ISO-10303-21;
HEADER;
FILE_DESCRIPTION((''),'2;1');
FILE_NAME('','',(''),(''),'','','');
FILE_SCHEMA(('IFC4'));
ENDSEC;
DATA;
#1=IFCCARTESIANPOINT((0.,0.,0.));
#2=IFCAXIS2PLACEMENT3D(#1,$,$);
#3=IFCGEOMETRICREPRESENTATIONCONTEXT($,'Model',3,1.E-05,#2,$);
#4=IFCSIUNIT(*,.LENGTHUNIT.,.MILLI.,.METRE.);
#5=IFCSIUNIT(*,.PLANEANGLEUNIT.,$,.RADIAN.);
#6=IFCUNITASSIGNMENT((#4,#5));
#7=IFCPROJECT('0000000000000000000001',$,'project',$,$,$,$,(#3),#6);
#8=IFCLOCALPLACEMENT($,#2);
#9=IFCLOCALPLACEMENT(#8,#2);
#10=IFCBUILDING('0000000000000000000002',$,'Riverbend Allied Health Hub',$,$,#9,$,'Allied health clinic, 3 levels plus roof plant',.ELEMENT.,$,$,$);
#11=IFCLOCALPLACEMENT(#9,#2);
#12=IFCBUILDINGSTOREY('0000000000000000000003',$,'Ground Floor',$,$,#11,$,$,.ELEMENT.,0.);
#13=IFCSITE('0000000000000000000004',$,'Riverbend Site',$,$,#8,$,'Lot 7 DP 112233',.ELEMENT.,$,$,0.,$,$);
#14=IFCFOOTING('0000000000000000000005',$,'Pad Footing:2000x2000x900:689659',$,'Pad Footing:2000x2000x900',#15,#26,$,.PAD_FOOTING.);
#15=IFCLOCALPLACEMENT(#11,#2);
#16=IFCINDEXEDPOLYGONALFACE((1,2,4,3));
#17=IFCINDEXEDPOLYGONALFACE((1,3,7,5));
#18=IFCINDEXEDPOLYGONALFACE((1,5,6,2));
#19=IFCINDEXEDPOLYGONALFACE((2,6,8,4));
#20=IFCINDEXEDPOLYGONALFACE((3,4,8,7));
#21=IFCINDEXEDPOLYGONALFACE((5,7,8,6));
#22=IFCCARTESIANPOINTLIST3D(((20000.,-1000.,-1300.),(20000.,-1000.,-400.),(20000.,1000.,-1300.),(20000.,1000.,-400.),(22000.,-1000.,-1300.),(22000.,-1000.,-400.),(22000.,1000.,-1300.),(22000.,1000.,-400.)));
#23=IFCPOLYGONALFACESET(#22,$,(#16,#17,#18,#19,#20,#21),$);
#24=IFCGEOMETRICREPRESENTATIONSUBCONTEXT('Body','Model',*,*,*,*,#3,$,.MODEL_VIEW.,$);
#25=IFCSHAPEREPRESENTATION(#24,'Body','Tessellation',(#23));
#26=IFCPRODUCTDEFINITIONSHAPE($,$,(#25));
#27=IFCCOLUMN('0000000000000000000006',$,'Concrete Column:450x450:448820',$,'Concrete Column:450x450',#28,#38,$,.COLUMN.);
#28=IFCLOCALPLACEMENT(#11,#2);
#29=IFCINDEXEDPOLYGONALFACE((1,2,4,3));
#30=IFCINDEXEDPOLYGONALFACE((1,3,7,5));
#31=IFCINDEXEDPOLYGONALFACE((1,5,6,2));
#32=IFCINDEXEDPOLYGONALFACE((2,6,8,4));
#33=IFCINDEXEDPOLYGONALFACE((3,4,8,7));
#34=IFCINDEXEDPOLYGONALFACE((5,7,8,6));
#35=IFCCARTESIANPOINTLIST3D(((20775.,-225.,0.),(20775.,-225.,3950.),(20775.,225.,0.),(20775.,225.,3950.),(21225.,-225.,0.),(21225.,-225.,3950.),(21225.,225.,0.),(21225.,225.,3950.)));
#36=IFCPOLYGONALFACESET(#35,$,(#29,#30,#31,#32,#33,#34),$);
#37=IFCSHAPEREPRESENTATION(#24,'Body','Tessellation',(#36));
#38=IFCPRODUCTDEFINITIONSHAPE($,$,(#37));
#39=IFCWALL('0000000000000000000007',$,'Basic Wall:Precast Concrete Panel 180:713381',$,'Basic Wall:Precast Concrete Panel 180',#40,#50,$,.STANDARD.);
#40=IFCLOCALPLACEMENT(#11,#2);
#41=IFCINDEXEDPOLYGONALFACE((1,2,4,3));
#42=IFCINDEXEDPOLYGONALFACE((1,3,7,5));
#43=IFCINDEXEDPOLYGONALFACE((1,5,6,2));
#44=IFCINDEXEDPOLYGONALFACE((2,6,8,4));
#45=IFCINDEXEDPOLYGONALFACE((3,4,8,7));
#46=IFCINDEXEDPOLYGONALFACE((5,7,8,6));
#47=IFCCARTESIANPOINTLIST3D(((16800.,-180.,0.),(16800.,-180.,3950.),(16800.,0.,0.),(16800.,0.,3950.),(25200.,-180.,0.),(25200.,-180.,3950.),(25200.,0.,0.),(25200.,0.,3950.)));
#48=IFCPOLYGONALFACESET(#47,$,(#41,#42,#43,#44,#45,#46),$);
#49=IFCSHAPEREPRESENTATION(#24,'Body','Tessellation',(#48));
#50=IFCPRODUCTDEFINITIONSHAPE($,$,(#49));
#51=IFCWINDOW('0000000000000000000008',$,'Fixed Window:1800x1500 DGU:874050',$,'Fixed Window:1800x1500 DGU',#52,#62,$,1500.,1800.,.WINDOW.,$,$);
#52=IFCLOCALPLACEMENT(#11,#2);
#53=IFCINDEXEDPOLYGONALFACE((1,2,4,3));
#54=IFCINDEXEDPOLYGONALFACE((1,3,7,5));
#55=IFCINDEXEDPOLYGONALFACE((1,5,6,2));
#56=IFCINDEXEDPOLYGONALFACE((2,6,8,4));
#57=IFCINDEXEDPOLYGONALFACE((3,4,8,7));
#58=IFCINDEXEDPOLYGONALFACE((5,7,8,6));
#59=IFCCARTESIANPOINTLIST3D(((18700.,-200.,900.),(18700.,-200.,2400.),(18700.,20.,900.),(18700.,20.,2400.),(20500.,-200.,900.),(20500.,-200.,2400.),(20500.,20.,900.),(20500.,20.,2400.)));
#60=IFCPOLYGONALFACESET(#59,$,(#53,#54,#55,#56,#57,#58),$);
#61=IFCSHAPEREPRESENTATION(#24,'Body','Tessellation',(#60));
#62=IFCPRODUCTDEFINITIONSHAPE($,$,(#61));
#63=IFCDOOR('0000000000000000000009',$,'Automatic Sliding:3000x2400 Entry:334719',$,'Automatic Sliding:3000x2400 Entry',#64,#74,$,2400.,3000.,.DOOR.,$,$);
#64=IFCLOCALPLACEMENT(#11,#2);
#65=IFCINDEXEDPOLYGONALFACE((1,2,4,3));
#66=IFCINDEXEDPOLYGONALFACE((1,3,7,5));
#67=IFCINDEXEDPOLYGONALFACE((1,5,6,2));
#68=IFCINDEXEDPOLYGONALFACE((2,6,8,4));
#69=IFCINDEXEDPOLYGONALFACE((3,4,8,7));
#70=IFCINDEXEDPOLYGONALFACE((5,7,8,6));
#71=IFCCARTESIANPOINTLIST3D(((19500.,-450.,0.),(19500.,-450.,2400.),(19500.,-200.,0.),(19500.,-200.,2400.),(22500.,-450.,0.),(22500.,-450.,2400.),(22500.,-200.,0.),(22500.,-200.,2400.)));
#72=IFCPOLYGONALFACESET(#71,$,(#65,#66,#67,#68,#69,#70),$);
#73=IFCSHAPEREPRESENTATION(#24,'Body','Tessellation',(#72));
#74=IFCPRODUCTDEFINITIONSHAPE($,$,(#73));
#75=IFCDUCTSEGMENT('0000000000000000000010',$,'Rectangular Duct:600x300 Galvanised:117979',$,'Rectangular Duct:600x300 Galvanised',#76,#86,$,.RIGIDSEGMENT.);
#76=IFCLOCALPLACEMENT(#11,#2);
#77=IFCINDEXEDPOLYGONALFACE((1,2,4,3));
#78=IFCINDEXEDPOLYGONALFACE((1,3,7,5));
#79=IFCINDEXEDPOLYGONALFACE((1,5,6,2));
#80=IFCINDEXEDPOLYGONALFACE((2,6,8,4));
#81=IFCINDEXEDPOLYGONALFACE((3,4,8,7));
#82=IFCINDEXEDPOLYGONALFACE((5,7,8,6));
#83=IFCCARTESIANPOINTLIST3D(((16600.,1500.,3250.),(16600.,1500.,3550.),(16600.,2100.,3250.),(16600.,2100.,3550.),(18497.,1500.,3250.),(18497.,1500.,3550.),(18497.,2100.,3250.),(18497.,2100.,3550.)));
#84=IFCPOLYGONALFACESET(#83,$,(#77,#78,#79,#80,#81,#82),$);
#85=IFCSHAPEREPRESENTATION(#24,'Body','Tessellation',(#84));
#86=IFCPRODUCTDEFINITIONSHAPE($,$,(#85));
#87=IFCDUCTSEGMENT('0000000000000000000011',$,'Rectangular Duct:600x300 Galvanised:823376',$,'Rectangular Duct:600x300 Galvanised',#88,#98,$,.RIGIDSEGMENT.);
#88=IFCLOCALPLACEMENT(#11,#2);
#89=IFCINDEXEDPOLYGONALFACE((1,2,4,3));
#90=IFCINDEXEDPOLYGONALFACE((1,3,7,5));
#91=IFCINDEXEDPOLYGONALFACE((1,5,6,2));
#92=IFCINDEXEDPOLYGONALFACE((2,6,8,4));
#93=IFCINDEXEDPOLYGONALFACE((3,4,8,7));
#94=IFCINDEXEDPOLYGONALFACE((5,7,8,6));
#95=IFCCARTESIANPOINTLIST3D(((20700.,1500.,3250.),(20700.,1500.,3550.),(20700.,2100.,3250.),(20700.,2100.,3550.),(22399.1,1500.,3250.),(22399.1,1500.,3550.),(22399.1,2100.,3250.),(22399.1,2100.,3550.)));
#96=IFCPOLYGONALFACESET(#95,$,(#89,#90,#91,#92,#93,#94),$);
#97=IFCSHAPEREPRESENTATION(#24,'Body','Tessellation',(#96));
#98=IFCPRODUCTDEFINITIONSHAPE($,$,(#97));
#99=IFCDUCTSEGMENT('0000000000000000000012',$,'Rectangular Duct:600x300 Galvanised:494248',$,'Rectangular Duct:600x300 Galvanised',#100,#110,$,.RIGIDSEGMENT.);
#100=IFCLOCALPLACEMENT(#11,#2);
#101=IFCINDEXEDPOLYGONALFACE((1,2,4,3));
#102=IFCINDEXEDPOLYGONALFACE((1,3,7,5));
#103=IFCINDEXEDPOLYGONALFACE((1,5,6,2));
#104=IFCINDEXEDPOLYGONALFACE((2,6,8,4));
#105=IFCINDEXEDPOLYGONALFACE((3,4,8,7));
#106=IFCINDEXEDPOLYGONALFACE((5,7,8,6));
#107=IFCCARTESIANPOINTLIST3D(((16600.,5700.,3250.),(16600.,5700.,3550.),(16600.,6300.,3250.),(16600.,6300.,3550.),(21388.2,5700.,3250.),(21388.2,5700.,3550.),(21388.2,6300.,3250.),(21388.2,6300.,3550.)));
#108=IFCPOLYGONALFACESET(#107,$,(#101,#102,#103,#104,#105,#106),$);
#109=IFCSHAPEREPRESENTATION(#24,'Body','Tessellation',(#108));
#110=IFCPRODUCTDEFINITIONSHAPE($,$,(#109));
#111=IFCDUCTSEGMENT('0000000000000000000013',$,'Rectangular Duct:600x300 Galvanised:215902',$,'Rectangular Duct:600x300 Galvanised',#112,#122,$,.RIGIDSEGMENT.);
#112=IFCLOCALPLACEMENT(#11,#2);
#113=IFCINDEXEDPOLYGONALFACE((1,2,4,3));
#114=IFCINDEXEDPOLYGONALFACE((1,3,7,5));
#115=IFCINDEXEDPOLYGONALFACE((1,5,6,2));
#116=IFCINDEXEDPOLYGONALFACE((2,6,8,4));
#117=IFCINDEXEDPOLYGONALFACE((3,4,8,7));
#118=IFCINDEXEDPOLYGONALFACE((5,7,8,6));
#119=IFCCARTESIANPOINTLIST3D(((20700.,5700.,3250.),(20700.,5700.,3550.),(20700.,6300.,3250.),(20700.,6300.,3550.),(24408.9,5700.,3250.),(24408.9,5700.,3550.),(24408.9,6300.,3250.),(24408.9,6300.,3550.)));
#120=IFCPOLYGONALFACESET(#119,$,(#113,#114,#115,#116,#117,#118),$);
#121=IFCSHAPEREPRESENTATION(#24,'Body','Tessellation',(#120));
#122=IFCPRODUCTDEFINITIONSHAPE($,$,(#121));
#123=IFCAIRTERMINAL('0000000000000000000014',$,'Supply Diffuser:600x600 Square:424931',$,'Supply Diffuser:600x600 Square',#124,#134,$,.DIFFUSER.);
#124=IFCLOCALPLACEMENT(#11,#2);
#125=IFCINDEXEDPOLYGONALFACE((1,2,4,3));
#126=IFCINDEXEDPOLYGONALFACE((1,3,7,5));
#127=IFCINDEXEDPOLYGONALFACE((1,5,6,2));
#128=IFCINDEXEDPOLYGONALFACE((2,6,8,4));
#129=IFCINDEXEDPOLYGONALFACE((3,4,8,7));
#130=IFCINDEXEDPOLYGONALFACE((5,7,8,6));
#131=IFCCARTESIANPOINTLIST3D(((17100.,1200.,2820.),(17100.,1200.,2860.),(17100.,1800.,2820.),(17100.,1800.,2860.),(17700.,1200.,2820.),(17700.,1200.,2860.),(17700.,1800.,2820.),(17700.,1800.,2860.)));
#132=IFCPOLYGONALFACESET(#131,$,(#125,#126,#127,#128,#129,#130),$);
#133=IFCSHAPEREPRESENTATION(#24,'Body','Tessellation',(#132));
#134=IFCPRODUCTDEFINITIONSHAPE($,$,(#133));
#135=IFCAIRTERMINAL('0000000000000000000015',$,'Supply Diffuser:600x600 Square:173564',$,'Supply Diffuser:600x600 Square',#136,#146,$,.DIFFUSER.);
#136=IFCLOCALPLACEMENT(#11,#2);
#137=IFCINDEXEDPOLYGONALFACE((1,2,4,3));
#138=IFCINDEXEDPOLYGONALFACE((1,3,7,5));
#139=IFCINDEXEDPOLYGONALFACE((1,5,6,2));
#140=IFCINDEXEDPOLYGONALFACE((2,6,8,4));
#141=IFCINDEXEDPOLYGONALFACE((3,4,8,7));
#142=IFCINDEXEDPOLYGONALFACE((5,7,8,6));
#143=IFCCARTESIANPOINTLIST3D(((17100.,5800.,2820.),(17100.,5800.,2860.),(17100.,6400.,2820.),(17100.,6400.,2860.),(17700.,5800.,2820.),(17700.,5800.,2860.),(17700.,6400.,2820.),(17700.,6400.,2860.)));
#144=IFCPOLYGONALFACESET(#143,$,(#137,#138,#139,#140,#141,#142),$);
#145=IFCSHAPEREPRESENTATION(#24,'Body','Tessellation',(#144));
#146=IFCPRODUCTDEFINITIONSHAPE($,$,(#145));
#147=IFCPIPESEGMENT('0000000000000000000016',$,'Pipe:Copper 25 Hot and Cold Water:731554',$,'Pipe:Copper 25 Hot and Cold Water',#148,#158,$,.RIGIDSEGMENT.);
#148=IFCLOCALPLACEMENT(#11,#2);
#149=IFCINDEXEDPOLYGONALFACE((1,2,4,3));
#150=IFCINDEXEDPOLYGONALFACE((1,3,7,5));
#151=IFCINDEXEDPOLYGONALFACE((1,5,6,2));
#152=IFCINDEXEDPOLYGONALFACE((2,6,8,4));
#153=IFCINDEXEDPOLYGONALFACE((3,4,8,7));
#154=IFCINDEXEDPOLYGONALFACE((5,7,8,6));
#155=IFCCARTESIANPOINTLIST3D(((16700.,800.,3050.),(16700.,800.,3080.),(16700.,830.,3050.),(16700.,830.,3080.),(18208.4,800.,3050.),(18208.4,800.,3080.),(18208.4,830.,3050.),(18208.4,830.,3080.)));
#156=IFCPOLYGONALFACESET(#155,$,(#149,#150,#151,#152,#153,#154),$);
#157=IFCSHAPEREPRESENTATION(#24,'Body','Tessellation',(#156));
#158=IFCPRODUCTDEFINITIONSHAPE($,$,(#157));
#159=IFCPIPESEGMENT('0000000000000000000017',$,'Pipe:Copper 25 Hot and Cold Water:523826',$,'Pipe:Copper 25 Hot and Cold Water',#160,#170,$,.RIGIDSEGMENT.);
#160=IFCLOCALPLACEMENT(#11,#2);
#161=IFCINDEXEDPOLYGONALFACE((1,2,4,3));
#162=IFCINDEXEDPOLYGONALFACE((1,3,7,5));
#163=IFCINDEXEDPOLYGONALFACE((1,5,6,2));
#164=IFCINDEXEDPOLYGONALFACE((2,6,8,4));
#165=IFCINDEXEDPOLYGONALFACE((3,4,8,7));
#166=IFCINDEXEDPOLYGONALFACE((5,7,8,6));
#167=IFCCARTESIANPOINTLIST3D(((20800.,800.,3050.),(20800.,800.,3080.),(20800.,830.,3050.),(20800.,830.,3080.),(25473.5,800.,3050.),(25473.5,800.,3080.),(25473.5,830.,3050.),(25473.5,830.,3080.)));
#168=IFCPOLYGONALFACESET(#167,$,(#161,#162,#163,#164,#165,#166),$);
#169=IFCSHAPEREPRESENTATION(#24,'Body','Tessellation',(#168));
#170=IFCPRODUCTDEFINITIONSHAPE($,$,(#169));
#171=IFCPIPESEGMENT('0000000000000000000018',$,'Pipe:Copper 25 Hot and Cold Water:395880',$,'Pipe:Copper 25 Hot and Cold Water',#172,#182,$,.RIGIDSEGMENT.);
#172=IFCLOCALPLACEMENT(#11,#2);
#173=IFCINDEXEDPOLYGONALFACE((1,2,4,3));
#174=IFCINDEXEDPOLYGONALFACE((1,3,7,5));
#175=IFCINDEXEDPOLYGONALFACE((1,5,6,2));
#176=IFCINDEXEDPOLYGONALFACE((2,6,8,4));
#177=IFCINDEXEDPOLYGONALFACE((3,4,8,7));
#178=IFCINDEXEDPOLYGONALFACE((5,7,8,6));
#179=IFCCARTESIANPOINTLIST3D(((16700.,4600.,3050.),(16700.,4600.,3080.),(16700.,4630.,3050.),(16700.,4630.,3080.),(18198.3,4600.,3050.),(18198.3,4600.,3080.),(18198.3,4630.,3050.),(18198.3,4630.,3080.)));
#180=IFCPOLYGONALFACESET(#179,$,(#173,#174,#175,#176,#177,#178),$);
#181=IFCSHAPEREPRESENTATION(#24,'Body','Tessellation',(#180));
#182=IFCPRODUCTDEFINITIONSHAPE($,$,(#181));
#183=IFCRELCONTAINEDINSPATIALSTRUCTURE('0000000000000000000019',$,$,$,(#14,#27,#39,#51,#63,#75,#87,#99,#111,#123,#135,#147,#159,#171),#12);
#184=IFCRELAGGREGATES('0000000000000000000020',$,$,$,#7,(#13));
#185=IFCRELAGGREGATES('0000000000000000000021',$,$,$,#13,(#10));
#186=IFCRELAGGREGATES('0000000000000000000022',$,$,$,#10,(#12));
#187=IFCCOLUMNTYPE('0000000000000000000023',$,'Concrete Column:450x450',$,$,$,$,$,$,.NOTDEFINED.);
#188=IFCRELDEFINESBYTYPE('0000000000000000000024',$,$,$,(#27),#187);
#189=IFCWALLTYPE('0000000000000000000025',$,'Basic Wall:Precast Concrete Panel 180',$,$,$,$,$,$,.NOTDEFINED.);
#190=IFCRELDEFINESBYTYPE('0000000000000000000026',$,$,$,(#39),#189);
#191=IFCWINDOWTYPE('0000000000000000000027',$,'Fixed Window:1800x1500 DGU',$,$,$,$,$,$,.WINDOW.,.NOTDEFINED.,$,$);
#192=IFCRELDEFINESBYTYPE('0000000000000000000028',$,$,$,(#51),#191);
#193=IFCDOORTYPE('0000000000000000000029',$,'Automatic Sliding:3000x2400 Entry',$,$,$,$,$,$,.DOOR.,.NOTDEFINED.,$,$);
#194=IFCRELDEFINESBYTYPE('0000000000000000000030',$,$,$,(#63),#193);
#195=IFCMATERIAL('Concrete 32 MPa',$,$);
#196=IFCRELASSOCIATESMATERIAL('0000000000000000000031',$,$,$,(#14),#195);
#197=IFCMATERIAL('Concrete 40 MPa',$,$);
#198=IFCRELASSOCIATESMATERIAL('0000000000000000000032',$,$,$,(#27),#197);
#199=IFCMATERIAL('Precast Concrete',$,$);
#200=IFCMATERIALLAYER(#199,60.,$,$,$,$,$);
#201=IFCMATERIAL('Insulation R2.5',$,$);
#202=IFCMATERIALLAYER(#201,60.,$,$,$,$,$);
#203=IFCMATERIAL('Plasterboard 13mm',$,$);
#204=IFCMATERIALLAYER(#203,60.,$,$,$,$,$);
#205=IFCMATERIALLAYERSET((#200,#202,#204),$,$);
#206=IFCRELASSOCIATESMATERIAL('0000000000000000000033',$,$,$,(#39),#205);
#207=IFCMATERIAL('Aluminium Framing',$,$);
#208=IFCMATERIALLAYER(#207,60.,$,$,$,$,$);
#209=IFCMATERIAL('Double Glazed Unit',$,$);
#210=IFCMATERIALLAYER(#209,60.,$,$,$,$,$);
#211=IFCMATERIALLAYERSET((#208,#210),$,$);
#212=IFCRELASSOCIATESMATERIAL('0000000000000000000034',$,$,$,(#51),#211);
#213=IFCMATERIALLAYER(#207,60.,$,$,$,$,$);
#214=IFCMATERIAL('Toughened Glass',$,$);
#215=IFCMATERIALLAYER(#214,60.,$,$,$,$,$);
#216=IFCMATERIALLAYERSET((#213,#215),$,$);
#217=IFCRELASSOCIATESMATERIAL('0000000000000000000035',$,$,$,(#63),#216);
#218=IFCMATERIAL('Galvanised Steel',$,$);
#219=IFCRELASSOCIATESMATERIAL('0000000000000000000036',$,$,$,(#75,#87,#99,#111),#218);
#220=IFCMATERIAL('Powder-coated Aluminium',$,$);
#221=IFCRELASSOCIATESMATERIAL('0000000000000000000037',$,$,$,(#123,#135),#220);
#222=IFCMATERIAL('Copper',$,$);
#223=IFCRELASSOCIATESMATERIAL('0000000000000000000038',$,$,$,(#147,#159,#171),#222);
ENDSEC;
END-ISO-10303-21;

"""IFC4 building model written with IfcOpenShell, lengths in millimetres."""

from ifc_helpers import new_model, si_unit, frame, frame_2d, origin, place, context, subcontext, project, spatial, rectangle, extrude, material, layer, layer_set, layer_usage, type_object, element, save


model = new_model("IFC4")

# Units and contexts
model_context = context("Model", 3, precision=1e-05, world=origin())
body_context = subcontext(model_context, "Body", "Model", "MODEL_VIEW")
ifc_project = project(units=[si_unit("LENGTHUNIT", "METRE", prefix="MILLI"), si_unit("PLANEANGLEUNIT", "RADIAN")], contexts=[model_context])

# Site, building, storey
site_placement = place(None, origin())
site = spatial("IfcSite", under=ifc_project, at=site_placement, Name="Riverbend Site", LongName="Lot 7 DP 112233", CompositionType="ELEMENT", RefElevation=0.0)
building_placement = place(site_placement, origin())
building = spatial("IfcBuilding", under=site, at=building_placement, Name="Riverbend Allied Health Hub", LongName="Allied health clinic, 3 levels plus roof plant", CompositionType="ELEMENT")
storey_placement = place(building_placement, origin())
storey = spatial("IfcBuildingStorey", under=building, at=storey_placement, Name="Ground Floor", CompositionType="ELEMENT", Elevation=0.0)

# Footing
ifc_material_1 = material(Name="Concrete 32 MPa")
footing_placement = place(storey_placement, frame((20000.0, -1000.0, -1300.0)))
element("IfcFooting", 1, at=footing_placement, inside=storey, material=ifc_material_1, Name="Pad Footing:2000x2000x900:689659", ObjectType="Pad Footing:2000x2000x900", PredefinedType="PAD_FOOTING", context=body_context, shape_type="SweptSolid", body=[
    extrude(rectangle(XDim=2000.0, YDim=2000.0, at=frame_2d((1000.0, 1000.0))), origin(), (0.0, 0.0, 1.0), 900.0),
])

# Column
ifc_material_2 = material(Name="Concrete 40 MPa")
column_type = type_object("IfcColumnType", Name="Concrete Column:450x450", PredefinedType="NOTDEFINED")
column_placement = place(storey_placement, frame((20775.0, -225.0, 0.0)))
element("IfcColumn", 2, at=column_placement, inside=storey, type_object=column_type, material=ifc_material_2, Name="Concrete Column:450x450:448820", ObjectType="Concrete Column:450x450", PredefinedType="COLUMN", context=body_context, shape_type="SweptSolid", body=[
    extrude(rectangle(XDim=450.0, YDim=450.0, at=frame_2d((225.0, 225.0))), origin(), (0.0, 0.0, 1.0), 3950.0),
])

# Wall
ifc_material_3 = material(Name="Precast Concrete")
ifc_layer_1 = layer(ifc_material_3, 60.0)
ifc_material_4 = material(Name="Insulation R2.5")
ifc_layer_2 = layer(ifc_material_4, 60.0)
ifc_material_5 = material(Name="Plasterboard 13mm")
ifc_layer_3 = layer(ifc_material_5, 60.0)
ifc_layer_set_1 = layer_set([ifc_layer_1, ifc_layer_2, ifc_layer_3])
ifc_layer_usage_1 = layer_usage(ifc_layer_set_1, "AXIS2", "POSITIVE", 0.0)
wall_type = type_object("IfcWallType", Name="Basic Wall:Precast Concrete Panel 180", PredefinedType="NOTDEFINED")
wall_placement = place(storey_placement, frame((16800.0, -180.0, 0.0)))
element("IfcWall", 3, at=wall_placement, inside=storey, type_object=wall_type, material=ifc_layer_usage_1, Name="Basic Wall:Precast Concrete Panel 180:713381", ObjectType="Basic Wall:Precast Concrete Panel 180", PredefinedType="STANDARD", context=body_context, shape_type="SweptSolid", body=[
    extrude(rectangle(XDim=8400.0, YDim=180.0, at=frame_2d((4200.0, 90.0))), origin(), (0.0, 0.0, 1.0), 3950.0),
])

# Window
ifc_material_6 = material(Name="Aluminium Framing")
ifc_layer_4 = layer(ifc_material_6, 60.0)
ifc_material_7 = material(Name="Double Glazed Unit")
ifc_layer_5 = layer(ifc_material_7, 60.0)
ifc_layer_set_2 = layer_set([ifc_layer_4, ifc_layer_5])
ifc_layer_usage_2 = layer_usage(ifc_layer_set_2, "AXIS2", "POSITIVE", 0.0)
window_type = type_object("IfcWindowType", Name="Fixed Window:1800x1500 DGU", PartitioningType="NOTDEFINED", PredefinedType="WINDOW")
window_placement = place(storey_placement, frame((18700.0, -200.0, 900.0)))
element("IfcWindow", 4, at=window_placement, inside=storey, type_object=window_type, material=ifc_layer_usage_2, Name="Fixed Window:1800x1500 DGU:874050", ObjectType="Fixed Window:1800x1500 DGU", OverallHeight=1500.0, OverallWidth=1800.0, PredefinedType="WINDOW", context=body_context, shape_type="SweptSolid", body=[
    extrude(rectangle(XDim=1800.0, YDim=220.0, at=frame_2d((900.0, 110.0))), origin(), (0.0, 0.0, 1.0), 1500.0),
])

# Door
ifc_layer_6 = layer(ifc_material_6, 60.0)
ifc_material_8 = material(Name="Toughened Glass")
ifc_layer_7 = layer(ifc_material_8, 60.0)
ifc_layer_set_3 = layer_set([ifc_layer_6, ifc_layer_7])
ifc_layer_usage_3 = layer_usage(ifc_layer_set_3, "AXIS2", "POSITIVE", 0.0)
door_type = type_object("IfcDoorType", Name="Automatic Sliding:3000x2400 Entry", OperationType="NOTDEFINED", PredefinedType="DOOR")
door_placement = place(storey_placement, frame((19500.0, -450.0, 0.0)))
element("IfcDoor", 5, at=door_placement, inside=storey, type_object=door_type, material=ifc_layer_usage_3, Name="Automatic Sliding:3000x2400 Entry:334719", ObjectType="Automatic Sliding:3000x2400 Entry", OverallHeight=2400.0, OverallWidth=3000.0, PredefinedType="DOOR", context=body_context, shape_type="SweptSolid", body=[
    extrude(rectangle(XDim=3000.0, YDim=250.0, at=frame_2d((1500.0, 125.0))), origin(), (0.0, 0.0, 1.0), 2400.0),
])

# Duct segments
ifc_material_9 = material(Name="Galvanised Steel")
duct_segment_1_placement = place(storey_placement, frame((16600.0, 1500.0, 3250.0)))
element("IfcDuctSegment", 6, at=duct_segment_1_placement, inside=storey, material=ifc_material_9, Name="Rectangular Duct:600x300 Galvanised:117979", ObjectType="Rectangular Duct:600x300 Galvanised", PredefinedType="RIGIDSEGMENT", context=body_context, shape_type="SweptSolid", body=[
    extrude(rectangle(XDim=1897.0, YDim=600.0, at=frame_2d((948.5, 300.0))), origin(), (0.0, 0.0, 1.0), 300.0),
])
duct_segment_2_placement = place(storey_placement, frame((20700.0, 1500.0, 3250.0)))
element("IfcDuctSegment", 7, at=duct_segment_2_placement, inside=storey, material=ifc_material_9, Name="Rectangular Duct:600x300 Galvanised:823376", ObjectType="Rectangular Duct:600x300 Galvanised", PredefinedType="RIGIDSEGMENT", context=body_context, shape_type="SweptSolid", body=[
    extrude(rectangle(XDim=1699.1, YDim=600.0, at=frame_2d((849.6, 300.0))), origin(), (0.0, 0.0, 1.0), 300.0),
])
duct_segment_3_placement = place(storey_placement, frame((16600.0, 5700.0, 3250.0)))
element("IfcDuctSegment", 8, at=duct_segment_3_placement, inside=storey, material=ifc_material_9, Name="Rectangular Duct:600x300 Galvanised:494248", ObjectType="Rectangular Duct:600x300 Galvanised", PredefinedType="RIGIDSEGMENT", context=body_context, shape_type="SweptSolid", body=[
    extrude(rectangle(XDim=4788.2, YDim=600.0, at=frame_2d((2394.1, 300.0))), origin(), (0.0, 0.0, 1.0), 300.0),
])
duct_segment_4_placement = place(storey_placement, frame((20700.0, 5700.0, 3250.0)))
element("IfcDuctSegment", 9, at=duct_segment_4_placement, inside=storey, material=ifc_material_9, Name="Rectangular Duct:600x300 Galvanised:215902", ObjectType="Rectangular Duct:600x300 Galvanised", PredefinedType="RIGIDSEGMENT", context=body_context, shape_type="SweptSolid", body=[
    extrude(rectangle(XDim=3708.9, YDim=600.0, at=frame_2d((1854.5, 300.0))), origin(), (0.0, 0.0, 1.0), 300.0),
])

# Air terminals
ifc_material_10 = material(Name="Powder-coated Aluminium")
for number, where, name in (
    (10, (17100.0, 1200.0, 2820.0), "Supply Diffuser:600x600 Square:424931"),
    (11, (17100.0, 5800.0, 2820.0), "Supply Diffuser:600x600 Square:173564"),
):
    element("IfcAirTerminal", number, at=place(storey_placement, frame(where)), inside=storey, material=ifc_material_10, Name=name, ObjectType="Supply Diffuser:600x600 Square", PredefinedType="DIFFUSER", context=body_context, shape_type="SweptSolid", body=[
        extrude(rectangle(XDim=600.0, YDim=600.0, at=frame_2d((300.0, 300.0))), origin(), (0.0, 0.0, 1.0), 40.0),
    ])

# Pipe segments
ifc_material_11 = material(Name="Copper")
pipe_segment_1_placement = place(storey_placement, frame((16700.0, 800.0, 3050.0)))
element("IfcPipeSegment", 12, at=pipe_segment_1_placement, inside=storey, material=ifc_material_11, Name="Pipe:Copper 25 Hot and Cold Water:731554", ObjectType="Pipe:Copper 25 Hot and Cold Water", PredefinedType="RIGIDSEGMENT", context=body_context, shape_type="SweptSolid", body=[
    extrude(rectangle(XDim=1508.4, YDim=30.0, at=frame_2d((754.2, 15.0))), origin(), (0.0, 0.0, 1.0), 30.0),
])
pipe_segment_2_placement = place(storey_placement, frame((20800.0, 800.0, 3050.0)))
element("IfcPipeSegment", 13, at=pipe_segment_2_placement, inside=storey, material=ifc_material_11, Name="Pipe:Copper 25 Hot and Cold Water:523826", ObjectType="Pipe:Copper 25 Hot and Cold Water", PredefinedType="RIGIDSEGMENT", context=body_context, shape_type="SweptSolid", body=[
    extrude(rectangle(XDim=4673.5, YDim=30.0, at=frame_2d((2336.8, 15.0))), origin(), (0.0, 0.0, 1.0), 30.0),
])
pipe_segment_3_placement = place(storey_placement, frame((16700.0, 4600.0, 3050.0)))
element("IfcPipeSegment", 14, at=pipe_segment_3_placement, inside=storey, material=ifc_material_11, Name="Pipe:Copper 25 Hot and Cold Water:395880", ObjectType="Pipe:Copper 25 Hot and Cold Water", PredefinedType="RIGIDSEGMENT", context=body_context, shape_type="SweptSolid", body=[
    extrude(rectangle(XDim=1498.3, YDim=30.0, at=frame_2d((749.2, 15.0))), origin(), (0.0, 0.0, 1.0), 30.0),
])

save(model, "model.ifc")
